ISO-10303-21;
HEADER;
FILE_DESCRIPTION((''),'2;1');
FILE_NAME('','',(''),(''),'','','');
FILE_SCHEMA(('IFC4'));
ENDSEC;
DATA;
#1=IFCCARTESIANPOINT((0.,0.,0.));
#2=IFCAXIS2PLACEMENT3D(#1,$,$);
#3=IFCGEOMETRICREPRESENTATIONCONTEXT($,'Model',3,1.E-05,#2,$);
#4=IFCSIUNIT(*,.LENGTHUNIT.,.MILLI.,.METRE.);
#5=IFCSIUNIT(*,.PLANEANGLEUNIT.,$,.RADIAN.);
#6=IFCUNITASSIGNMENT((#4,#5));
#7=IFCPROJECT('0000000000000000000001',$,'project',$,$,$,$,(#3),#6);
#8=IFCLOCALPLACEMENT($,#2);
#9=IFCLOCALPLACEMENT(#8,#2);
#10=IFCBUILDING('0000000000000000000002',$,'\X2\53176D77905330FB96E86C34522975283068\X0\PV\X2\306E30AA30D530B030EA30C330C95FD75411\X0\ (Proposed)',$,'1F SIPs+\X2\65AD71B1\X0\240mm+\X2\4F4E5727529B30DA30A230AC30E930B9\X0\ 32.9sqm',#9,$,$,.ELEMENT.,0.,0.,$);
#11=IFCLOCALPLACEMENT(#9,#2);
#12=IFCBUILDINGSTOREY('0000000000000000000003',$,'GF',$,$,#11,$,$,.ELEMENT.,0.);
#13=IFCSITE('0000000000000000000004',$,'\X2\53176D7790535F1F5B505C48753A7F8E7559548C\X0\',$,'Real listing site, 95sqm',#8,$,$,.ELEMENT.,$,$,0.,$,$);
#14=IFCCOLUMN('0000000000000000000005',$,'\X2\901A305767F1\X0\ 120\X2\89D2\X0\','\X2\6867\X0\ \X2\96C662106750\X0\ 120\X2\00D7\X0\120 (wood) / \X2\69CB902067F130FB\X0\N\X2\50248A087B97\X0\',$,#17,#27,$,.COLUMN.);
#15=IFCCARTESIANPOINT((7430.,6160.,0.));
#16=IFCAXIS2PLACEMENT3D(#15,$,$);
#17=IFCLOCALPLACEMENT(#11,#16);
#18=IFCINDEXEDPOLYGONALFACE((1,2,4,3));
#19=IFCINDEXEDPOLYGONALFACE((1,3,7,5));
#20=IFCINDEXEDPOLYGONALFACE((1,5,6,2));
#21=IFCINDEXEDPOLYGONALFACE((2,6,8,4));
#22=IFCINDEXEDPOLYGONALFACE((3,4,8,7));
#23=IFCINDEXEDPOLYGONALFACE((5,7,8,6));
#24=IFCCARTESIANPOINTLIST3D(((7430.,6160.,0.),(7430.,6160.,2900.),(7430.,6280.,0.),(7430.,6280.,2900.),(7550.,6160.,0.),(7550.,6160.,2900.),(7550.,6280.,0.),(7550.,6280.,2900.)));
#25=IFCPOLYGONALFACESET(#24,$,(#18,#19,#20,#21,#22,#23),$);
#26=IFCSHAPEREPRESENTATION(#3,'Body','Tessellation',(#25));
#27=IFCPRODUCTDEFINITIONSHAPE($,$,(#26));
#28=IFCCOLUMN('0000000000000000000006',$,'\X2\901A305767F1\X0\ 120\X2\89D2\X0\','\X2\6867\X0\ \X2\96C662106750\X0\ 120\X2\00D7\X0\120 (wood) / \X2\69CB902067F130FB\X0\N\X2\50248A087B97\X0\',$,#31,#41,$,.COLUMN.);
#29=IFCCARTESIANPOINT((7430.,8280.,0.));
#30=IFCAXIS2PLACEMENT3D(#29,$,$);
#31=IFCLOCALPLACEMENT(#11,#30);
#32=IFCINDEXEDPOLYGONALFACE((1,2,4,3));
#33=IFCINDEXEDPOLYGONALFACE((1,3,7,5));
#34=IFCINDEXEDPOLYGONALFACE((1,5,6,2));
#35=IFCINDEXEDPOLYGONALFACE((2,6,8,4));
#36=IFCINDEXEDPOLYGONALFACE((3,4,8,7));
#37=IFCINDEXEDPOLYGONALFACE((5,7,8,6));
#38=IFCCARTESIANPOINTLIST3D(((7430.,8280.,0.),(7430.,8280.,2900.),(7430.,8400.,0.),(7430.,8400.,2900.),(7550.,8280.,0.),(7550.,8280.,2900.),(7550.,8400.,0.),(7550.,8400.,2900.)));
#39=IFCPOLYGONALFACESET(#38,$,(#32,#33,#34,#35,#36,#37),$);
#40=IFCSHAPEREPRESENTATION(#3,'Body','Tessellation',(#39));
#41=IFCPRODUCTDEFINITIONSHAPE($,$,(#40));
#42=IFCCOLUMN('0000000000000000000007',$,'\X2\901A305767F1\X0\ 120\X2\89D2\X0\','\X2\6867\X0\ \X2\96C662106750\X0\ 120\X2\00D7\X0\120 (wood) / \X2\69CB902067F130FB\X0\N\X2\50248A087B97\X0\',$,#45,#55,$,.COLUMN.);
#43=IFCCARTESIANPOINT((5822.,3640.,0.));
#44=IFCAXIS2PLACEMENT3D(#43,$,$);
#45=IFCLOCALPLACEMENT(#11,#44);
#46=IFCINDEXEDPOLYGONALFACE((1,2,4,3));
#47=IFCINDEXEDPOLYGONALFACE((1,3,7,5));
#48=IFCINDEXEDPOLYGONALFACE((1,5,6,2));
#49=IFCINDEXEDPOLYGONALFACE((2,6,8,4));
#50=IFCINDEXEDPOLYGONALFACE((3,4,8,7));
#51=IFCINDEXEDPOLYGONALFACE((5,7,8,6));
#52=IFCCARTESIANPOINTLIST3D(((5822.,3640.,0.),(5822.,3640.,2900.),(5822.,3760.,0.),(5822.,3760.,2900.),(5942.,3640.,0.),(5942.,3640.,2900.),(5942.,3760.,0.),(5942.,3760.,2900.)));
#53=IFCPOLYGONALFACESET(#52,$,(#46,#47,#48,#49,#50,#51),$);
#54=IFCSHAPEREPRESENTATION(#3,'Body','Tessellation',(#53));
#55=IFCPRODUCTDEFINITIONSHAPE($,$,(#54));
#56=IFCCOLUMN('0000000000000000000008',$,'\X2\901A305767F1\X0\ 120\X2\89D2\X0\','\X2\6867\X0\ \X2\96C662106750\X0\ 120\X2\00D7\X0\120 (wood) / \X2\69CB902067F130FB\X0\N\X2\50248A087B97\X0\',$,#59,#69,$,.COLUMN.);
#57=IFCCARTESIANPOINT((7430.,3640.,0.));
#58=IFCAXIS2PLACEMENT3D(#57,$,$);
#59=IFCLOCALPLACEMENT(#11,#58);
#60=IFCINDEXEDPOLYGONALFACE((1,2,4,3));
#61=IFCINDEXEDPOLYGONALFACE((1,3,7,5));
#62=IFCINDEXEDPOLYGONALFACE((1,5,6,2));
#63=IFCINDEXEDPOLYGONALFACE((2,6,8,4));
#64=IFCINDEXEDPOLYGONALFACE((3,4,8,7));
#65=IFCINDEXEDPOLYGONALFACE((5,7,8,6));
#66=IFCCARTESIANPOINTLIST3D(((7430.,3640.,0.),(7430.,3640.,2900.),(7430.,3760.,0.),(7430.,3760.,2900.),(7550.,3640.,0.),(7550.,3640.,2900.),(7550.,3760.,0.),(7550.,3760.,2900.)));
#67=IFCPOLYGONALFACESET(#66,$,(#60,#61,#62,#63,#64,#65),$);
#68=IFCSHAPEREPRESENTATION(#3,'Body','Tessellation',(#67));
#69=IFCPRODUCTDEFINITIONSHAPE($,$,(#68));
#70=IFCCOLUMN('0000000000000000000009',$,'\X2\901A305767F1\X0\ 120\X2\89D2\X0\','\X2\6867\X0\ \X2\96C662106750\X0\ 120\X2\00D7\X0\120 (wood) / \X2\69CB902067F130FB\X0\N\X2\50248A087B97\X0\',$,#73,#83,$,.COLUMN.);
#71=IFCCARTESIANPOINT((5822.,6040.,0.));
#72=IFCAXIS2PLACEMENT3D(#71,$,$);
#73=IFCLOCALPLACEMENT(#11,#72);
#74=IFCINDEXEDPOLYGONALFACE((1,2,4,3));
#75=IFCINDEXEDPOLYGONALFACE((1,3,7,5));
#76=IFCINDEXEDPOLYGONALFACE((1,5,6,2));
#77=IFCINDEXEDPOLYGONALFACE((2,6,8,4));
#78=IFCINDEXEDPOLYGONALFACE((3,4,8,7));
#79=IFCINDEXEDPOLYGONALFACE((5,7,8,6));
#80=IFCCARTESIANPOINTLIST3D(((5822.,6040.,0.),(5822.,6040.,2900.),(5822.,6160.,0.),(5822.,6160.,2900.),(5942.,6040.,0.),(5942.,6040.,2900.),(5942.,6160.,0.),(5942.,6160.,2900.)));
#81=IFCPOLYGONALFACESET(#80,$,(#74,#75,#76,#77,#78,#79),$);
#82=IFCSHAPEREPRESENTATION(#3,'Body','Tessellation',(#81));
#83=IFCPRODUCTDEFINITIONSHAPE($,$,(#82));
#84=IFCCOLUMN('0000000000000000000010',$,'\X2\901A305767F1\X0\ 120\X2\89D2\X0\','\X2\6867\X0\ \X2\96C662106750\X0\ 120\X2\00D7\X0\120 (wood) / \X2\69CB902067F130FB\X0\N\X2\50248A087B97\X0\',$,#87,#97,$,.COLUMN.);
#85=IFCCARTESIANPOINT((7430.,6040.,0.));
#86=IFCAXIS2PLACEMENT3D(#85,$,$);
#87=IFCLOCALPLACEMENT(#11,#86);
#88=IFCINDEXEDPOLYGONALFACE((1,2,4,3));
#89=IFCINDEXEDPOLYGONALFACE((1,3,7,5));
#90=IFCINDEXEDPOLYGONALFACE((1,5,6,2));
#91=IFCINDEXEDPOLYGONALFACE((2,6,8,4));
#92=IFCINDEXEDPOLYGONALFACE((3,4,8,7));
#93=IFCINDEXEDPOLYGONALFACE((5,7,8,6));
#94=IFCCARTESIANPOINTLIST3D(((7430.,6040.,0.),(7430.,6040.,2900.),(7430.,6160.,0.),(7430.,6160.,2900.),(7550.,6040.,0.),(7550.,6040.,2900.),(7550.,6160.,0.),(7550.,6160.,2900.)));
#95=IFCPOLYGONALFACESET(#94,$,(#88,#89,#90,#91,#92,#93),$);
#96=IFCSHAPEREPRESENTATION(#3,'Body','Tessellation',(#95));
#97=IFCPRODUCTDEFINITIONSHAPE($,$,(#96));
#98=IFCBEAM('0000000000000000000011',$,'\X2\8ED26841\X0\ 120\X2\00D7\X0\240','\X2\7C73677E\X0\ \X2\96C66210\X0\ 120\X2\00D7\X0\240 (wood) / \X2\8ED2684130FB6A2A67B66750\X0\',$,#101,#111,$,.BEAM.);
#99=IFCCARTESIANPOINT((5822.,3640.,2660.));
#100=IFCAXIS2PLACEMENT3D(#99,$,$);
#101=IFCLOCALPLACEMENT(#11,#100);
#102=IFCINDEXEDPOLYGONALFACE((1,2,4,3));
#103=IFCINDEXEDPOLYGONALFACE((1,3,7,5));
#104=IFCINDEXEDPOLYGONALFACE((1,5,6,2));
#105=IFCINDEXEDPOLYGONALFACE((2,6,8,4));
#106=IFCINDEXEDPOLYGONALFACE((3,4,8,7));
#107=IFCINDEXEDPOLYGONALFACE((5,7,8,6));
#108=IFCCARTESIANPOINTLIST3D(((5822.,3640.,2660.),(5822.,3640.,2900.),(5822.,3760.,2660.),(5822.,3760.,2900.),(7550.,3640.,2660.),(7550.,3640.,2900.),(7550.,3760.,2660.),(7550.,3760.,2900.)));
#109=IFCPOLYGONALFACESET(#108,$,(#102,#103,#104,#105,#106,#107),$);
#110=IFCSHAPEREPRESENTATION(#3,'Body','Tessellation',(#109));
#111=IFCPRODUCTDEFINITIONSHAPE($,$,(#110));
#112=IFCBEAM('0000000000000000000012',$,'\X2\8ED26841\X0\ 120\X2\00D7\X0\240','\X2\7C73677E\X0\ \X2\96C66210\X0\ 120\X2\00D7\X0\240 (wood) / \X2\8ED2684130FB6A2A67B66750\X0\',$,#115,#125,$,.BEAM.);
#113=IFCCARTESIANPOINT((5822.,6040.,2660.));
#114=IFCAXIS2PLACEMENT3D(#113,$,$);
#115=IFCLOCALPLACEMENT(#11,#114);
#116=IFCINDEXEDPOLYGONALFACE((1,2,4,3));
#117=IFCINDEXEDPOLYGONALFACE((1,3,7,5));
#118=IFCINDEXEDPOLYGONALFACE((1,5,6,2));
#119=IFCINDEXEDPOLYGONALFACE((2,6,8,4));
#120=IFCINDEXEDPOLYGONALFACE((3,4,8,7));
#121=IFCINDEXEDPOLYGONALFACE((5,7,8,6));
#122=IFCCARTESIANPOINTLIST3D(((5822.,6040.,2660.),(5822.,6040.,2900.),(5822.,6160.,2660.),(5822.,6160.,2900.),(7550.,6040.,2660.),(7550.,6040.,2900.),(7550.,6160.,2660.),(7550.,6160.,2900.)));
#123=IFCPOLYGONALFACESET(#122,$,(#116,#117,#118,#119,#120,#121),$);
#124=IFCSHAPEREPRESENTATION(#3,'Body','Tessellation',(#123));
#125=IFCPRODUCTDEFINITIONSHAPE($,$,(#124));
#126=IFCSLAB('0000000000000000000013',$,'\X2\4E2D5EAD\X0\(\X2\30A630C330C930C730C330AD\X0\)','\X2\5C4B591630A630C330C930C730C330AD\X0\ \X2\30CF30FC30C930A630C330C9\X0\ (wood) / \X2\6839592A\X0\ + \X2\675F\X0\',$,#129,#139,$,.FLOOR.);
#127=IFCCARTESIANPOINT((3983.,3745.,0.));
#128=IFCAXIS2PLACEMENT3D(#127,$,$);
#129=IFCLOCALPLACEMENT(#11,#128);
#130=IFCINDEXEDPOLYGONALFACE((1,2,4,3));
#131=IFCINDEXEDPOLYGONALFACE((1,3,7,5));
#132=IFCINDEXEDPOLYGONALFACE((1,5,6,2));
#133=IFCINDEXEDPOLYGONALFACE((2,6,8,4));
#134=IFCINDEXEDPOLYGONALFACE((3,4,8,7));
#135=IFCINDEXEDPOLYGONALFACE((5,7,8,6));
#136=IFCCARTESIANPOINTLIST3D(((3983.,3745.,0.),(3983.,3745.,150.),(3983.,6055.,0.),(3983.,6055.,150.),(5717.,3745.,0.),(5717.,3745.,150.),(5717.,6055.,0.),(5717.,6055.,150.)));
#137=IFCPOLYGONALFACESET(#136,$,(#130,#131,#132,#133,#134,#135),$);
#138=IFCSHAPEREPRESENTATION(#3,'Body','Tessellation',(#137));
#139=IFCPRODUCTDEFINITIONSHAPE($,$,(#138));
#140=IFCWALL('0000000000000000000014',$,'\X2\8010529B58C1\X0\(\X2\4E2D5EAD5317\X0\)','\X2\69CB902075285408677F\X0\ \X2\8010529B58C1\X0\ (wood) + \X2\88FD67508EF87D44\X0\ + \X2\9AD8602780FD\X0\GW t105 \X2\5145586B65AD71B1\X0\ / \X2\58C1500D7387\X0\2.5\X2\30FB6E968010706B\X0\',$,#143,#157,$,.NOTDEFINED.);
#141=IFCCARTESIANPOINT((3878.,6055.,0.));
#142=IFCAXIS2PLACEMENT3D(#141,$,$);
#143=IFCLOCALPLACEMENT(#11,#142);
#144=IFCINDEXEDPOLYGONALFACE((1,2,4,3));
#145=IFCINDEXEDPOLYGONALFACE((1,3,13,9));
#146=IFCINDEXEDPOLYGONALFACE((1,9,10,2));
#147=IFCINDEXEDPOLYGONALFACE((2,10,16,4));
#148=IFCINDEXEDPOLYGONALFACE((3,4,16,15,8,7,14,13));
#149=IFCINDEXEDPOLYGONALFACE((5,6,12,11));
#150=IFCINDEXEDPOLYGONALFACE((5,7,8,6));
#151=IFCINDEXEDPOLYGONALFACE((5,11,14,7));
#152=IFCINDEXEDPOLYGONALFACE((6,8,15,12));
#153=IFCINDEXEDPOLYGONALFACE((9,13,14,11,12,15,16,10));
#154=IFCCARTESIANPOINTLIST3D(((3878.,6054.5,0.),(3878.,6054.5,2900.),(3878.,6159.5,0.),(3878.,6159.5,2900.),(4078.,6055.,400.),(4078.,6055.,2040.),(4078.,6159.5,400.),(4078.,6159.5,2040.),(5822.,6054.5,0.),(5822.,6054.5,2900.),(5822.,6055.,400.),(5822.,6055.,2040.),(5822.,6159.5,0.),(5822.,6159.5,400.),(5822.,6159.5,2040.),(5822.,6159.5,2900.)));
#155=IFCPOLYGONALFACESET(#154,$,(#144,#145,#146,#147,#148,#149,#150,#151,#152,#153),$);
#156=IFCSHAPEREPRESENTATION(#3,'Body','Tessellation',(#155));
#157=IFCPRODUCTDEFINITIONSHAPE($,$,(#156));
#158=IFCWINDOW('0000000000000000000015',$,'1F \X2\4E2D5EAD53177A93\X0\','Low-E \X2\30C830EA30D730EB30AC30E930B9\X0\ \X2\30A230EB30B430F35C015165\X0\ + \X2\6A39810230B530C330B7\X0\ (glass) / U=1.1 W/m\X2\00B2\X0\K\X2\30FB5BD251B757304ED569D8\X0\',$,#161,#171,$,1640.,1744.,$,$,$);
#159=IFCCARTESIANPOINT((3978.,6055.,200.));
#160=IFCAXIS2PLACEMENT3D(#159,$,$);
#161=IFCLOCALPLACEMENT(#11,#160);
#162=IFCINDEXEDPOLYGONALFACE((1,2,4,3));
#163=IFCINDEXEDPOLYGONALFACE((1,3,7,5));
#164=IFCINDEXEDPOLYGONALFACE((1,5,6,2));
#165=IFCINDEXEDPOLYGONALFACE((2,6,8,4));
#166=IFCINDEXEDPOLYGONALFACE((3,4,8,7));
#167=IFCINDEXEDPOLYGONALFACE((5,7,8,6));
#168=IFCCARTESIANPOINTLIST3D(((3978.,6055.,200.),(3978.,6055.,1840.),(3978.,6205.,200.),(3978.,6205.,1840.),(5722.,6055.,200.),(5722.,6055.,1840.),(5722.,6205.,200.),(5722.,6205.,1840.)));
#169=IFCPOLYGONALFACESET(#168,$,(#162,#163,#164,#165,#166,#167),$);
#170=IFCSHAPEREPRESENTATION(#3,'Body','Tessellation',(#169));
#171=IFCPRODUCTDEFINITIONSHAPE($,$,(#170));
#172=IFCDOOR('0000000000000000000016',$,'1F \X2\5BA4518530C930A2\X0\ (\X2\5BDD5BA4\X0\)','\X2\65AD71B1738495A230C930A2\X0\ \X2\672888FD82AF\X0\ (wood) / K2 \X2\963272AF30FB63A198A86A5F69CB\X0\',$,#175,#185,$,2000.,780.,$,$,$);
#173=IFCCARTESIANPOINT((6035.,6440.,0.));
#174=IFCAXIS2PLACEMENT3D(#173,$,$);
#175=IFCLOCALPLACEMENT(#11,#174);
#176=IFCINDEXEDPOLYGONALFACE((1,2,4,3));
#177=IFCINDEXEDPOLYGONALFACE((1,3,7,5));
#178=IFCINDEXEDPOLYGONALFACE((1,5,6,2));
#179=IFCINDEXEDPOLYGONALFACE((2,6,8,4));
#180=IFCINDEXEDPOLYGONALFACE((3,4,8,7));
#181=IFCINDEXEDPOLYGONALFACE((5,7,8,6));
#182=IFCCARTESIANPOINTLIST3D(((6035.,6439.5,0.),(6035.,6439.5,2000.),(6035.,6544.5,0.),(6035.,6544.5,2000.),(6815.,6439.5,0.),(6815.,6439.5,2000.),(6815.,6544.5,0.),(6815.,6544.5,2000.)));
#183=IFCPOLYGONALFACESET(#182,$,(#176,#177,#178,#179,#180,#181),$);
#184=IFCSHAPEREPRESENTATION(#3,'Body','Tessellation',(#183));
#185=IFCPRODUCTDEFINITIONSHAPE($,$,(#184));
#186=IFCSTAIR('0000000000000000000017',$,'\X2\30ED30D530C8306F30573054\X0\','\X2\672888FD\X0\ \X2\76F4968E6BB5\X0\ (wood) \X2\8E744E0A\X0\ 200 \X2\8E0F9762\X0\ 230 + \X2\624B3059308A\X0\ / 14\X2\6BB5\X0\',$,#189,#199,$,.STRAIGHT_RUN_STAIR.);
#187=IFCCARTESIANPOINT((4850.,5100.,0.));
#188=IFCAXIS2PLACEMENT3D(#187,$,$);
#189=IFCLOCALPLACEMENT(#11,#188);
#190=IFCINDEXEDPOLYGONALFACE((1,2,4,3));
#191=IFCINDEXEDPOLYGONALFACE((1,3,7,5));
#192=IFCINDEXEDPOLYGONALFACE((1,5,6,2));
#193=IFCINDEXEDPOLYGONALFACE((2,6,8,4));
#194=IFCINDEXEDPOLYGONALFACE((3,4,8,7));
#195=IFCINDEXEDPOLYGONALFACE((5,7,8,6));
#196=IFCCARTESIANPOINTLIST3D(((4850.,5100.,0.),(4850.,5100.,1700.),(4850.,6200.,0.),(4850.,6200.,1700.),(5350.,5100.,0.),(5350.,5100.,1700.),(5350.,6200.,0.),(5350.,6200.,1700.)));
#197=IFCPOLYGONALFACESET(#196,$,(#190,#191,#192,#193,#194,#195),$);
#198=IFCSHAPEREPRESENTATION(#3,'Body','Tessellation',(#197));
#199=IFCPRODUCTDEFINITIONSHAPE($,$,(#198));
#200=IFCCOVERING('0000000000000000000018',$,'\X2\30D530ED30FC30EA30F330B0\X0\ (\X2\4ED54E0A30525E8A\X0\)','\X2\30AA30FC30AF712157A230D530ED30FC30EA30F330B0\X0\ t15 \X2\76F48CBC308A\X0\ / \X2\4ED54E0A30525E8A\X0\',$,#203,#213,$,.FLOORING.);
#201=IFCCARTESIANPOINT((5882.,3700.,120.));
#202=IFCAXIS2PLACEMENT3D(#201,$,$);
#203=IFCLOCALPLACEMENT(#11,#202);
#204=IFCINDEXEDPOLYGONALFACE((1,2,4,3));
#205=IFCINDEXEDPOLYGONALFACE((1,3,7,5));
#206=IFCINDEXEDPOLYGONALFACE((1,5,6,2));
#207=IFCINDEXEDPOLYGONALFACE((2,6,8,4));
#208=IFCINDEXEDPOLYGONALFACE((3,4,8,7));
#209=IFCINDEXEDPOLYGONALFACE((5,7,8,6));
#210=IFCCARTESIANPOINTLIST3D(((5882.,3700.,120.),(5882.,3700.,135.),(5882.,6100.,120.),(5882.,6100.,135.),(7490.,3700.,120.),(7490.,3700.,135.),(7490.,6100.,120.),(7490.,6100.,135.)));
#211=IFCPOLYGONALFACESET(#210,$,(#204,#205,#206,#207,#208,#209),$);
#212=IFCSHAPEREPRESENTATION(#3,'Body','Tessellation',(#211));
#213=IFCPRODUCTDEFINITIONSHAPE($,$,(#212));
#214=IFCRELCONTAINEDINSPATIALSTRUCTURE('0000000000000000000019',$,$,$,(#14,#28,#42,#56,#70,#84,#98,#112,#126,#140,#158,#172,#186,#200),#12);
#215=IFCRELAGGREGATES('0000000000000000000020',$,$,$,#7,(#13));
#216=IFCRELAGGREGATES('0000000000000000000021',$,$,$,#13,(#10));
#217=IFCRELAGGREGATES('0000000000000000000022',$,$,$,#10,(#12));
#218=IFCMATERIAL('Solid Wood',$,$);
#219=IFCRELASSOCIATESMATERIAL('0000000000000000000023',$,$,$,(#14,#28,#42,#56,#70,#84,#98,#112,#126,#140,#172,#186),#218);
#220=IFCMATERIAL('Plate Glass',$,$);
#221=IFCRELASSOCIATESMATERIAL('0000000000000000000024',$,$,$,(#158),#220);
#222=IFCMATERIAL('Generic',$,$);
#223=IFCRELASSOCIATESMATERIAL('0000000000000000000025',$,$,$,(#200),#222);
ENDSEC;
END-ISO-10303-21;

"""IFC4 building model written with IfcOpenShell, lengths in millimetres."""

from ifc_helpers import new_model, si_unit, frame, frame_2d, origin, place, context, project, spatial, rectangle, extrude, material, element, fill, save


model = new_model("IFC4")

# Units and contexts
model_context = context("Model", 3, precision=1e-05, world=origin())
ifc_project = project(units=[si_unit("LENGTHUNIT", "METRE", prefix="MILLI"), si_unit("PLANEANGLEUNIT", "RADIAN")], contexts=[model_context])

# Site, building, storey
site_placement = place(None, origin())
site = spatial("IfcSite", under=ifc_project, at=site_placement, Name="北海道弟子屈町美留和", ObjectType="Real listing site, 95sqm", CompositionType="ELEMENT", RefElevation=0.0)
building_placement = place(site_placement, origin())
building = spatial("IfcBuilding", under=site, at=building_placement, Name="北海道・雨水利用とPVのオフグリッド志向 (Proposed)", ObjectType="1F SIPs+断熱240mm+低圧力ペアガラス 32.9sqm", CompositionType="ELEMENT", ElevationOfRefHeight=0.0, ElevationOfTerrain=0.0)
storey_placement = place(building_placement, origin())
storey = spatial("IfcBuildingStorey", under=building, at=storey_placement, Name="GF", CompositionType="ELEMENT", Elevation=0.0)

# Columns
ifc_material_1 = material(Name="Solid Wood")
column_1_placement = place(storey_placement, frame((7430.0, 6160.0, 0.0)))
element("IfcColumn", 1, at=column_1_placement, inside=storey, material=ifc_material_1, Name="通し柱 120角", Description="桧 集成材 120×120 (wood) / 構造柱・N値計算", PredefinedType="COLUMN", context=model_context, shape_type="SweptSolid", body=[
    extrude(rectangle(XDim=120.0, YDim=120.0, at=frame_2d((60.0, 60.0))), frame((7430.0, 6160.0, 0.0)), (0.0, 0.0, 1.0), 2900.0),
])
column_2_placement = place(storey_placement, frame((7430.0, 8280.0, 0.0)))
element("IfcColumn", 2, at=column_2_placement, inside=storey, material=ifc_material_1, Name="通し柱 120角", Description="桧 集成材 120×120 (wood) / 構造柱・N値計算", PredefinedType="COLUMN", context=model_context, shape_type="SweptSolid", body=[
    extrude(rectangle(XDim=120.0, YDim=120.0, at=frame_2d((60.0, 60.0))), frame((7430.0, 8280.0, 0.0)), (0.0, 0.0, 1.0), 2900.0),
])
column_3_placement = place(storey_placement, frame((5822.0, 3640.0, 0.0)))
element("IfcColumn", 3, at=column_3_placement, inside=storey, material=ifc_material_1, Name="通し柱 120角", Description="桧 集成材 120×120 (wood) / 構造柱・N値計算", PredefinedType="COLUMN", context=model_context, shape_type="SweptSolid", body=[
    extrude(rectangle(XDim=120.0, YDim=120.0, at=frame_2d((60.0, 60.0))), frame((5822.0, 3640.0, 0.0)), (0.0, 0.0, 1.0), 2900.0),
])
column_4_placement = place(storey_placement, frame((7430.0, 3640.0, 0.0)))
element("IfcColumn", 4, at=column_4_placement, inside=storey, material=ifc_material_1, Name="通し柱 120角", Description="桧 集成材 120×120 (wood) / 構造柱・N値計算", PredefinedType="COLUMN", context=model_context, shape_type="SweptSolid", body=[
    extrude(rectangle(XDim=120.0, YDim=120.0, at=frame_2d((60.0, 60.0))), frame((7430.0, 3640.0, 0.0)), (0.0, 0.0, 1.0), 2900.0),
])
column_5_placement = place(storey_placement, frame((5822.0, 6040.0, 0.0)))
element("IfcColumn", 5, at=column_5_placement, inside=storey, material=ifc_material_1, Name="通し柱 120角", Description="桧 集成材 120×120 (wood) / 構造柱・N値計算", PredefinedType="COLUMN", context=model_context, shape_type="SweptSolid", body=[
    extrude(rectangle(XDim=120.0, YDim=120.0, at=frame_2d((60.0, 60.0))), frame((5822.0, 6040.0, 0.0)), (0.0, 0.0, 1.0), 2900.0),
])
column_6_placement = place(storey_placement, frame((7430.0, 6040.0, 0.0)))
element("IfcColumn", 6, at=column_6_placement, inside=storey, material=ifc_material_1, Name="通し柱 120角", Description="桧 集成材 120×120 (wood) / 構造柱・N値計算", PredefinedType="COLUMN", context=model_context, shape_type="SweptSolid", body=[
    extrude(rectangle(XDim=120.0, YDim=120.0, at=frame_2d((60.0, 60.0))), frame((7430.0, 6040.0, 0.0)), (0.0, 0.0, 1.0), 2900.0),
])

# Beams
beam_1_placement = place(storey_placement, frame((5822.0, 3640.0, 2660.0)))
element("IfcBeam", 7, at=beam_1_placement, inside=storey, material=ifc_material_1, Name="軒桁 120×240", Description="米松 集成 120×240 (wood) / 軒桁・横架材", PredefinedType="BEAM", context=model_context, shape_type="SweptSolid", body=[
    extrude(rectangle(XDim=1728.0, YDim=120.0, at=frame_2d((864.0, 60.0))), frame((5822.0, 3640.0, 2660.0)), (0.0, 0.0, 1.0), 240.0),
])
beam_2_placement = place(storey_placement, frame((5822.0, 6040.0, 2660.0)))
element("IfcBeam", 8, at=beam_2_placement, inside=storey, material=ifc_material_1, Name="軒桁 120×240", Description="米松 集成 120×240 (wood) / 軒桁・横架材", PredefinedType="BEAM", context=model_context, shape_type="SweptSolid", body=[
    extrude(rectangle(XDim=1728.0, YDim=120.0, at=frame_2d((864.0, 60.0))), frame((5822.0, 6040.0, 2660.0)), (0.0, 0.0, 1.0), 240.0),
])

# Slab
slab_placement = place(storey_placement, frame((3983.0, 3745.0, 0.0)))
element("IfcSlab", 9, at=slab_placement, inside=storey, material=ifc_material_1, Name="中庭(ウッドデッキ)", Description="屋外ウッドデッキ ハードウッド (wood) / 根太 + 束", PredefinedType="FLOOR", context=model_context, shape_type="SweptSolid", body=[
    extrude(rectangle(XDim=1734.0, YDim=2310.0, at=frame_2d((867.0, 1155.0))), frame((3983.0, 3745.0, 0.0)), (0.0, 0.0, 1.0), 150.0),
])

# Wall, opening, window
wall_1_placement = place(storey_placement, frame((3878.0, 6055.0, 0.0)))
wall_1 = element("IfcWall", 10, at=wall_1_placement, inside=storey, material=ifc_material_1, Name="耐力壁(中庭北)", Description="構造用合板 耐力壁 (wood) + 製材軸組 + 高性能GW t105 充填断熱 / 壁倍率2.5・準耐火", PredefinedType="NOTDEFINED", context=model_context, shape_type="SweptSolid", body=[
    extrude(rectangle(XDim=1944.0, YDim=105.0, at=frame_2d((972.0, 52.0))), frame((3878.0, 6055.0, 0.0)), (0.0, 0.0, 1.0), 2900.0),
])
opening_placement = place(storey_placement, frame((3978.0, 6055.0, 200.0)))
opening = element("IfcOpeningElement", 11, at=opening_placement, cuts=wall_1, PredefinedType="NOTDEFINED", context=model_context, shape_type="SweptSolid", body=[
    extrude(rectangle(XDim=1744.0, YDim=150.0, at=frame_2d((872.0, 75.0))), frame((3978.0, 6055.0, 200.0)), (0.0, 0.0, 1.0), 1640.0),
])
ifc_material_2 = material(Name="Plate Glass")
window_placement = place(storey_placement, frame((3978.0, 6055.0, 200.0)))
window = element("IfcWindow", 12, at=window_placement, inside=storey, material=ifc_material_2, Name="1F 中庭北窓", Description="Low-E トリプルガラス アルゴン封入 + 樹脂サッシ (glass) / U=1.1 W/m²K・寒冷地仕様", OverallHeight=1640.0, OverallWidth=1744.0, context=model_context, shape_type="SweptSolid", body=[
    extrude(rectangle(XDim=1744.0, YDim=150.0, at=frame_2d((872.0, 75.0))), frame((3978.0, 6055.0, 200.0)), (0.0, 0.0, 1.0), 1640.0),
])
fill(opening, window)

# Door
door_placement = place(storey_placement, frame((6035.0, 6440.0, 0.0)))
element("IfcDoor", 13, at=door_placement, inside=storey, material=ifc_material_1, Name="1F 室内ドア (寝室)", Description="断熱玄関ドア 木製芯 (wood) / K2 防犯・採風機構", OverallHeight=2000.0, OverallWidth=780.0, context=model_context, shape_type="SweptSolid", body=[
    extrude(rectangle(XDim=780.0, YDim=105.0, at=frame_2d((390.0, 52.0))), frame((6035.0, 6440.0, 0.0)), (0.0, 0.0, 1.0), 2000.0),
])

# Stair
stair_placement = place(storey_placement, frame((4850.0, 5100.0, 0.0)))
element("IfcStair", 14, at=stair_placement, inside=storey, material=ifc_material_1, Name="ロフトはしご", Description="木製 直階段 (wood) 蹴上 200 踏面 230 + 手すり / 14段", PredefinedType="STRAIGHT_RUN_STAIR", context=model_context, shape_type="SweptSolid", body=[
    extrude(rectangle(XDim=500.0, YDim=1100.0, at=frame_2d((250.0, 550.0))), frame((4850.0, 5100.0, 0.0)), (0.0, 0.0, 1.0), 1700.0),
])

# Covering
ifc_material_3 = material(Name="Generic")
covering_placement = place(storey_placement, frame((5882.0, 3700.0, 120.0)))
element("IfcCovering", 15, at=covering_placement, inside=storey, material=ifc_material_3, Name="フローリング (仕上げ床)", Description="オーク無垢フローリング t15 直貼り / 仕上げ床", PredefinedType="FLOORING", context=model_context, shape_type="SweptSolid", body=[
    extrude(rectangle(XDim=1608.0, YDim=2400.0, at=frame_2d((804.0, 1200.0))), frame((5882.0, 3700.0, 120.0)), (0.0, 0.0, 1.0), 15.0),
])

save(model, "model.ifc")
